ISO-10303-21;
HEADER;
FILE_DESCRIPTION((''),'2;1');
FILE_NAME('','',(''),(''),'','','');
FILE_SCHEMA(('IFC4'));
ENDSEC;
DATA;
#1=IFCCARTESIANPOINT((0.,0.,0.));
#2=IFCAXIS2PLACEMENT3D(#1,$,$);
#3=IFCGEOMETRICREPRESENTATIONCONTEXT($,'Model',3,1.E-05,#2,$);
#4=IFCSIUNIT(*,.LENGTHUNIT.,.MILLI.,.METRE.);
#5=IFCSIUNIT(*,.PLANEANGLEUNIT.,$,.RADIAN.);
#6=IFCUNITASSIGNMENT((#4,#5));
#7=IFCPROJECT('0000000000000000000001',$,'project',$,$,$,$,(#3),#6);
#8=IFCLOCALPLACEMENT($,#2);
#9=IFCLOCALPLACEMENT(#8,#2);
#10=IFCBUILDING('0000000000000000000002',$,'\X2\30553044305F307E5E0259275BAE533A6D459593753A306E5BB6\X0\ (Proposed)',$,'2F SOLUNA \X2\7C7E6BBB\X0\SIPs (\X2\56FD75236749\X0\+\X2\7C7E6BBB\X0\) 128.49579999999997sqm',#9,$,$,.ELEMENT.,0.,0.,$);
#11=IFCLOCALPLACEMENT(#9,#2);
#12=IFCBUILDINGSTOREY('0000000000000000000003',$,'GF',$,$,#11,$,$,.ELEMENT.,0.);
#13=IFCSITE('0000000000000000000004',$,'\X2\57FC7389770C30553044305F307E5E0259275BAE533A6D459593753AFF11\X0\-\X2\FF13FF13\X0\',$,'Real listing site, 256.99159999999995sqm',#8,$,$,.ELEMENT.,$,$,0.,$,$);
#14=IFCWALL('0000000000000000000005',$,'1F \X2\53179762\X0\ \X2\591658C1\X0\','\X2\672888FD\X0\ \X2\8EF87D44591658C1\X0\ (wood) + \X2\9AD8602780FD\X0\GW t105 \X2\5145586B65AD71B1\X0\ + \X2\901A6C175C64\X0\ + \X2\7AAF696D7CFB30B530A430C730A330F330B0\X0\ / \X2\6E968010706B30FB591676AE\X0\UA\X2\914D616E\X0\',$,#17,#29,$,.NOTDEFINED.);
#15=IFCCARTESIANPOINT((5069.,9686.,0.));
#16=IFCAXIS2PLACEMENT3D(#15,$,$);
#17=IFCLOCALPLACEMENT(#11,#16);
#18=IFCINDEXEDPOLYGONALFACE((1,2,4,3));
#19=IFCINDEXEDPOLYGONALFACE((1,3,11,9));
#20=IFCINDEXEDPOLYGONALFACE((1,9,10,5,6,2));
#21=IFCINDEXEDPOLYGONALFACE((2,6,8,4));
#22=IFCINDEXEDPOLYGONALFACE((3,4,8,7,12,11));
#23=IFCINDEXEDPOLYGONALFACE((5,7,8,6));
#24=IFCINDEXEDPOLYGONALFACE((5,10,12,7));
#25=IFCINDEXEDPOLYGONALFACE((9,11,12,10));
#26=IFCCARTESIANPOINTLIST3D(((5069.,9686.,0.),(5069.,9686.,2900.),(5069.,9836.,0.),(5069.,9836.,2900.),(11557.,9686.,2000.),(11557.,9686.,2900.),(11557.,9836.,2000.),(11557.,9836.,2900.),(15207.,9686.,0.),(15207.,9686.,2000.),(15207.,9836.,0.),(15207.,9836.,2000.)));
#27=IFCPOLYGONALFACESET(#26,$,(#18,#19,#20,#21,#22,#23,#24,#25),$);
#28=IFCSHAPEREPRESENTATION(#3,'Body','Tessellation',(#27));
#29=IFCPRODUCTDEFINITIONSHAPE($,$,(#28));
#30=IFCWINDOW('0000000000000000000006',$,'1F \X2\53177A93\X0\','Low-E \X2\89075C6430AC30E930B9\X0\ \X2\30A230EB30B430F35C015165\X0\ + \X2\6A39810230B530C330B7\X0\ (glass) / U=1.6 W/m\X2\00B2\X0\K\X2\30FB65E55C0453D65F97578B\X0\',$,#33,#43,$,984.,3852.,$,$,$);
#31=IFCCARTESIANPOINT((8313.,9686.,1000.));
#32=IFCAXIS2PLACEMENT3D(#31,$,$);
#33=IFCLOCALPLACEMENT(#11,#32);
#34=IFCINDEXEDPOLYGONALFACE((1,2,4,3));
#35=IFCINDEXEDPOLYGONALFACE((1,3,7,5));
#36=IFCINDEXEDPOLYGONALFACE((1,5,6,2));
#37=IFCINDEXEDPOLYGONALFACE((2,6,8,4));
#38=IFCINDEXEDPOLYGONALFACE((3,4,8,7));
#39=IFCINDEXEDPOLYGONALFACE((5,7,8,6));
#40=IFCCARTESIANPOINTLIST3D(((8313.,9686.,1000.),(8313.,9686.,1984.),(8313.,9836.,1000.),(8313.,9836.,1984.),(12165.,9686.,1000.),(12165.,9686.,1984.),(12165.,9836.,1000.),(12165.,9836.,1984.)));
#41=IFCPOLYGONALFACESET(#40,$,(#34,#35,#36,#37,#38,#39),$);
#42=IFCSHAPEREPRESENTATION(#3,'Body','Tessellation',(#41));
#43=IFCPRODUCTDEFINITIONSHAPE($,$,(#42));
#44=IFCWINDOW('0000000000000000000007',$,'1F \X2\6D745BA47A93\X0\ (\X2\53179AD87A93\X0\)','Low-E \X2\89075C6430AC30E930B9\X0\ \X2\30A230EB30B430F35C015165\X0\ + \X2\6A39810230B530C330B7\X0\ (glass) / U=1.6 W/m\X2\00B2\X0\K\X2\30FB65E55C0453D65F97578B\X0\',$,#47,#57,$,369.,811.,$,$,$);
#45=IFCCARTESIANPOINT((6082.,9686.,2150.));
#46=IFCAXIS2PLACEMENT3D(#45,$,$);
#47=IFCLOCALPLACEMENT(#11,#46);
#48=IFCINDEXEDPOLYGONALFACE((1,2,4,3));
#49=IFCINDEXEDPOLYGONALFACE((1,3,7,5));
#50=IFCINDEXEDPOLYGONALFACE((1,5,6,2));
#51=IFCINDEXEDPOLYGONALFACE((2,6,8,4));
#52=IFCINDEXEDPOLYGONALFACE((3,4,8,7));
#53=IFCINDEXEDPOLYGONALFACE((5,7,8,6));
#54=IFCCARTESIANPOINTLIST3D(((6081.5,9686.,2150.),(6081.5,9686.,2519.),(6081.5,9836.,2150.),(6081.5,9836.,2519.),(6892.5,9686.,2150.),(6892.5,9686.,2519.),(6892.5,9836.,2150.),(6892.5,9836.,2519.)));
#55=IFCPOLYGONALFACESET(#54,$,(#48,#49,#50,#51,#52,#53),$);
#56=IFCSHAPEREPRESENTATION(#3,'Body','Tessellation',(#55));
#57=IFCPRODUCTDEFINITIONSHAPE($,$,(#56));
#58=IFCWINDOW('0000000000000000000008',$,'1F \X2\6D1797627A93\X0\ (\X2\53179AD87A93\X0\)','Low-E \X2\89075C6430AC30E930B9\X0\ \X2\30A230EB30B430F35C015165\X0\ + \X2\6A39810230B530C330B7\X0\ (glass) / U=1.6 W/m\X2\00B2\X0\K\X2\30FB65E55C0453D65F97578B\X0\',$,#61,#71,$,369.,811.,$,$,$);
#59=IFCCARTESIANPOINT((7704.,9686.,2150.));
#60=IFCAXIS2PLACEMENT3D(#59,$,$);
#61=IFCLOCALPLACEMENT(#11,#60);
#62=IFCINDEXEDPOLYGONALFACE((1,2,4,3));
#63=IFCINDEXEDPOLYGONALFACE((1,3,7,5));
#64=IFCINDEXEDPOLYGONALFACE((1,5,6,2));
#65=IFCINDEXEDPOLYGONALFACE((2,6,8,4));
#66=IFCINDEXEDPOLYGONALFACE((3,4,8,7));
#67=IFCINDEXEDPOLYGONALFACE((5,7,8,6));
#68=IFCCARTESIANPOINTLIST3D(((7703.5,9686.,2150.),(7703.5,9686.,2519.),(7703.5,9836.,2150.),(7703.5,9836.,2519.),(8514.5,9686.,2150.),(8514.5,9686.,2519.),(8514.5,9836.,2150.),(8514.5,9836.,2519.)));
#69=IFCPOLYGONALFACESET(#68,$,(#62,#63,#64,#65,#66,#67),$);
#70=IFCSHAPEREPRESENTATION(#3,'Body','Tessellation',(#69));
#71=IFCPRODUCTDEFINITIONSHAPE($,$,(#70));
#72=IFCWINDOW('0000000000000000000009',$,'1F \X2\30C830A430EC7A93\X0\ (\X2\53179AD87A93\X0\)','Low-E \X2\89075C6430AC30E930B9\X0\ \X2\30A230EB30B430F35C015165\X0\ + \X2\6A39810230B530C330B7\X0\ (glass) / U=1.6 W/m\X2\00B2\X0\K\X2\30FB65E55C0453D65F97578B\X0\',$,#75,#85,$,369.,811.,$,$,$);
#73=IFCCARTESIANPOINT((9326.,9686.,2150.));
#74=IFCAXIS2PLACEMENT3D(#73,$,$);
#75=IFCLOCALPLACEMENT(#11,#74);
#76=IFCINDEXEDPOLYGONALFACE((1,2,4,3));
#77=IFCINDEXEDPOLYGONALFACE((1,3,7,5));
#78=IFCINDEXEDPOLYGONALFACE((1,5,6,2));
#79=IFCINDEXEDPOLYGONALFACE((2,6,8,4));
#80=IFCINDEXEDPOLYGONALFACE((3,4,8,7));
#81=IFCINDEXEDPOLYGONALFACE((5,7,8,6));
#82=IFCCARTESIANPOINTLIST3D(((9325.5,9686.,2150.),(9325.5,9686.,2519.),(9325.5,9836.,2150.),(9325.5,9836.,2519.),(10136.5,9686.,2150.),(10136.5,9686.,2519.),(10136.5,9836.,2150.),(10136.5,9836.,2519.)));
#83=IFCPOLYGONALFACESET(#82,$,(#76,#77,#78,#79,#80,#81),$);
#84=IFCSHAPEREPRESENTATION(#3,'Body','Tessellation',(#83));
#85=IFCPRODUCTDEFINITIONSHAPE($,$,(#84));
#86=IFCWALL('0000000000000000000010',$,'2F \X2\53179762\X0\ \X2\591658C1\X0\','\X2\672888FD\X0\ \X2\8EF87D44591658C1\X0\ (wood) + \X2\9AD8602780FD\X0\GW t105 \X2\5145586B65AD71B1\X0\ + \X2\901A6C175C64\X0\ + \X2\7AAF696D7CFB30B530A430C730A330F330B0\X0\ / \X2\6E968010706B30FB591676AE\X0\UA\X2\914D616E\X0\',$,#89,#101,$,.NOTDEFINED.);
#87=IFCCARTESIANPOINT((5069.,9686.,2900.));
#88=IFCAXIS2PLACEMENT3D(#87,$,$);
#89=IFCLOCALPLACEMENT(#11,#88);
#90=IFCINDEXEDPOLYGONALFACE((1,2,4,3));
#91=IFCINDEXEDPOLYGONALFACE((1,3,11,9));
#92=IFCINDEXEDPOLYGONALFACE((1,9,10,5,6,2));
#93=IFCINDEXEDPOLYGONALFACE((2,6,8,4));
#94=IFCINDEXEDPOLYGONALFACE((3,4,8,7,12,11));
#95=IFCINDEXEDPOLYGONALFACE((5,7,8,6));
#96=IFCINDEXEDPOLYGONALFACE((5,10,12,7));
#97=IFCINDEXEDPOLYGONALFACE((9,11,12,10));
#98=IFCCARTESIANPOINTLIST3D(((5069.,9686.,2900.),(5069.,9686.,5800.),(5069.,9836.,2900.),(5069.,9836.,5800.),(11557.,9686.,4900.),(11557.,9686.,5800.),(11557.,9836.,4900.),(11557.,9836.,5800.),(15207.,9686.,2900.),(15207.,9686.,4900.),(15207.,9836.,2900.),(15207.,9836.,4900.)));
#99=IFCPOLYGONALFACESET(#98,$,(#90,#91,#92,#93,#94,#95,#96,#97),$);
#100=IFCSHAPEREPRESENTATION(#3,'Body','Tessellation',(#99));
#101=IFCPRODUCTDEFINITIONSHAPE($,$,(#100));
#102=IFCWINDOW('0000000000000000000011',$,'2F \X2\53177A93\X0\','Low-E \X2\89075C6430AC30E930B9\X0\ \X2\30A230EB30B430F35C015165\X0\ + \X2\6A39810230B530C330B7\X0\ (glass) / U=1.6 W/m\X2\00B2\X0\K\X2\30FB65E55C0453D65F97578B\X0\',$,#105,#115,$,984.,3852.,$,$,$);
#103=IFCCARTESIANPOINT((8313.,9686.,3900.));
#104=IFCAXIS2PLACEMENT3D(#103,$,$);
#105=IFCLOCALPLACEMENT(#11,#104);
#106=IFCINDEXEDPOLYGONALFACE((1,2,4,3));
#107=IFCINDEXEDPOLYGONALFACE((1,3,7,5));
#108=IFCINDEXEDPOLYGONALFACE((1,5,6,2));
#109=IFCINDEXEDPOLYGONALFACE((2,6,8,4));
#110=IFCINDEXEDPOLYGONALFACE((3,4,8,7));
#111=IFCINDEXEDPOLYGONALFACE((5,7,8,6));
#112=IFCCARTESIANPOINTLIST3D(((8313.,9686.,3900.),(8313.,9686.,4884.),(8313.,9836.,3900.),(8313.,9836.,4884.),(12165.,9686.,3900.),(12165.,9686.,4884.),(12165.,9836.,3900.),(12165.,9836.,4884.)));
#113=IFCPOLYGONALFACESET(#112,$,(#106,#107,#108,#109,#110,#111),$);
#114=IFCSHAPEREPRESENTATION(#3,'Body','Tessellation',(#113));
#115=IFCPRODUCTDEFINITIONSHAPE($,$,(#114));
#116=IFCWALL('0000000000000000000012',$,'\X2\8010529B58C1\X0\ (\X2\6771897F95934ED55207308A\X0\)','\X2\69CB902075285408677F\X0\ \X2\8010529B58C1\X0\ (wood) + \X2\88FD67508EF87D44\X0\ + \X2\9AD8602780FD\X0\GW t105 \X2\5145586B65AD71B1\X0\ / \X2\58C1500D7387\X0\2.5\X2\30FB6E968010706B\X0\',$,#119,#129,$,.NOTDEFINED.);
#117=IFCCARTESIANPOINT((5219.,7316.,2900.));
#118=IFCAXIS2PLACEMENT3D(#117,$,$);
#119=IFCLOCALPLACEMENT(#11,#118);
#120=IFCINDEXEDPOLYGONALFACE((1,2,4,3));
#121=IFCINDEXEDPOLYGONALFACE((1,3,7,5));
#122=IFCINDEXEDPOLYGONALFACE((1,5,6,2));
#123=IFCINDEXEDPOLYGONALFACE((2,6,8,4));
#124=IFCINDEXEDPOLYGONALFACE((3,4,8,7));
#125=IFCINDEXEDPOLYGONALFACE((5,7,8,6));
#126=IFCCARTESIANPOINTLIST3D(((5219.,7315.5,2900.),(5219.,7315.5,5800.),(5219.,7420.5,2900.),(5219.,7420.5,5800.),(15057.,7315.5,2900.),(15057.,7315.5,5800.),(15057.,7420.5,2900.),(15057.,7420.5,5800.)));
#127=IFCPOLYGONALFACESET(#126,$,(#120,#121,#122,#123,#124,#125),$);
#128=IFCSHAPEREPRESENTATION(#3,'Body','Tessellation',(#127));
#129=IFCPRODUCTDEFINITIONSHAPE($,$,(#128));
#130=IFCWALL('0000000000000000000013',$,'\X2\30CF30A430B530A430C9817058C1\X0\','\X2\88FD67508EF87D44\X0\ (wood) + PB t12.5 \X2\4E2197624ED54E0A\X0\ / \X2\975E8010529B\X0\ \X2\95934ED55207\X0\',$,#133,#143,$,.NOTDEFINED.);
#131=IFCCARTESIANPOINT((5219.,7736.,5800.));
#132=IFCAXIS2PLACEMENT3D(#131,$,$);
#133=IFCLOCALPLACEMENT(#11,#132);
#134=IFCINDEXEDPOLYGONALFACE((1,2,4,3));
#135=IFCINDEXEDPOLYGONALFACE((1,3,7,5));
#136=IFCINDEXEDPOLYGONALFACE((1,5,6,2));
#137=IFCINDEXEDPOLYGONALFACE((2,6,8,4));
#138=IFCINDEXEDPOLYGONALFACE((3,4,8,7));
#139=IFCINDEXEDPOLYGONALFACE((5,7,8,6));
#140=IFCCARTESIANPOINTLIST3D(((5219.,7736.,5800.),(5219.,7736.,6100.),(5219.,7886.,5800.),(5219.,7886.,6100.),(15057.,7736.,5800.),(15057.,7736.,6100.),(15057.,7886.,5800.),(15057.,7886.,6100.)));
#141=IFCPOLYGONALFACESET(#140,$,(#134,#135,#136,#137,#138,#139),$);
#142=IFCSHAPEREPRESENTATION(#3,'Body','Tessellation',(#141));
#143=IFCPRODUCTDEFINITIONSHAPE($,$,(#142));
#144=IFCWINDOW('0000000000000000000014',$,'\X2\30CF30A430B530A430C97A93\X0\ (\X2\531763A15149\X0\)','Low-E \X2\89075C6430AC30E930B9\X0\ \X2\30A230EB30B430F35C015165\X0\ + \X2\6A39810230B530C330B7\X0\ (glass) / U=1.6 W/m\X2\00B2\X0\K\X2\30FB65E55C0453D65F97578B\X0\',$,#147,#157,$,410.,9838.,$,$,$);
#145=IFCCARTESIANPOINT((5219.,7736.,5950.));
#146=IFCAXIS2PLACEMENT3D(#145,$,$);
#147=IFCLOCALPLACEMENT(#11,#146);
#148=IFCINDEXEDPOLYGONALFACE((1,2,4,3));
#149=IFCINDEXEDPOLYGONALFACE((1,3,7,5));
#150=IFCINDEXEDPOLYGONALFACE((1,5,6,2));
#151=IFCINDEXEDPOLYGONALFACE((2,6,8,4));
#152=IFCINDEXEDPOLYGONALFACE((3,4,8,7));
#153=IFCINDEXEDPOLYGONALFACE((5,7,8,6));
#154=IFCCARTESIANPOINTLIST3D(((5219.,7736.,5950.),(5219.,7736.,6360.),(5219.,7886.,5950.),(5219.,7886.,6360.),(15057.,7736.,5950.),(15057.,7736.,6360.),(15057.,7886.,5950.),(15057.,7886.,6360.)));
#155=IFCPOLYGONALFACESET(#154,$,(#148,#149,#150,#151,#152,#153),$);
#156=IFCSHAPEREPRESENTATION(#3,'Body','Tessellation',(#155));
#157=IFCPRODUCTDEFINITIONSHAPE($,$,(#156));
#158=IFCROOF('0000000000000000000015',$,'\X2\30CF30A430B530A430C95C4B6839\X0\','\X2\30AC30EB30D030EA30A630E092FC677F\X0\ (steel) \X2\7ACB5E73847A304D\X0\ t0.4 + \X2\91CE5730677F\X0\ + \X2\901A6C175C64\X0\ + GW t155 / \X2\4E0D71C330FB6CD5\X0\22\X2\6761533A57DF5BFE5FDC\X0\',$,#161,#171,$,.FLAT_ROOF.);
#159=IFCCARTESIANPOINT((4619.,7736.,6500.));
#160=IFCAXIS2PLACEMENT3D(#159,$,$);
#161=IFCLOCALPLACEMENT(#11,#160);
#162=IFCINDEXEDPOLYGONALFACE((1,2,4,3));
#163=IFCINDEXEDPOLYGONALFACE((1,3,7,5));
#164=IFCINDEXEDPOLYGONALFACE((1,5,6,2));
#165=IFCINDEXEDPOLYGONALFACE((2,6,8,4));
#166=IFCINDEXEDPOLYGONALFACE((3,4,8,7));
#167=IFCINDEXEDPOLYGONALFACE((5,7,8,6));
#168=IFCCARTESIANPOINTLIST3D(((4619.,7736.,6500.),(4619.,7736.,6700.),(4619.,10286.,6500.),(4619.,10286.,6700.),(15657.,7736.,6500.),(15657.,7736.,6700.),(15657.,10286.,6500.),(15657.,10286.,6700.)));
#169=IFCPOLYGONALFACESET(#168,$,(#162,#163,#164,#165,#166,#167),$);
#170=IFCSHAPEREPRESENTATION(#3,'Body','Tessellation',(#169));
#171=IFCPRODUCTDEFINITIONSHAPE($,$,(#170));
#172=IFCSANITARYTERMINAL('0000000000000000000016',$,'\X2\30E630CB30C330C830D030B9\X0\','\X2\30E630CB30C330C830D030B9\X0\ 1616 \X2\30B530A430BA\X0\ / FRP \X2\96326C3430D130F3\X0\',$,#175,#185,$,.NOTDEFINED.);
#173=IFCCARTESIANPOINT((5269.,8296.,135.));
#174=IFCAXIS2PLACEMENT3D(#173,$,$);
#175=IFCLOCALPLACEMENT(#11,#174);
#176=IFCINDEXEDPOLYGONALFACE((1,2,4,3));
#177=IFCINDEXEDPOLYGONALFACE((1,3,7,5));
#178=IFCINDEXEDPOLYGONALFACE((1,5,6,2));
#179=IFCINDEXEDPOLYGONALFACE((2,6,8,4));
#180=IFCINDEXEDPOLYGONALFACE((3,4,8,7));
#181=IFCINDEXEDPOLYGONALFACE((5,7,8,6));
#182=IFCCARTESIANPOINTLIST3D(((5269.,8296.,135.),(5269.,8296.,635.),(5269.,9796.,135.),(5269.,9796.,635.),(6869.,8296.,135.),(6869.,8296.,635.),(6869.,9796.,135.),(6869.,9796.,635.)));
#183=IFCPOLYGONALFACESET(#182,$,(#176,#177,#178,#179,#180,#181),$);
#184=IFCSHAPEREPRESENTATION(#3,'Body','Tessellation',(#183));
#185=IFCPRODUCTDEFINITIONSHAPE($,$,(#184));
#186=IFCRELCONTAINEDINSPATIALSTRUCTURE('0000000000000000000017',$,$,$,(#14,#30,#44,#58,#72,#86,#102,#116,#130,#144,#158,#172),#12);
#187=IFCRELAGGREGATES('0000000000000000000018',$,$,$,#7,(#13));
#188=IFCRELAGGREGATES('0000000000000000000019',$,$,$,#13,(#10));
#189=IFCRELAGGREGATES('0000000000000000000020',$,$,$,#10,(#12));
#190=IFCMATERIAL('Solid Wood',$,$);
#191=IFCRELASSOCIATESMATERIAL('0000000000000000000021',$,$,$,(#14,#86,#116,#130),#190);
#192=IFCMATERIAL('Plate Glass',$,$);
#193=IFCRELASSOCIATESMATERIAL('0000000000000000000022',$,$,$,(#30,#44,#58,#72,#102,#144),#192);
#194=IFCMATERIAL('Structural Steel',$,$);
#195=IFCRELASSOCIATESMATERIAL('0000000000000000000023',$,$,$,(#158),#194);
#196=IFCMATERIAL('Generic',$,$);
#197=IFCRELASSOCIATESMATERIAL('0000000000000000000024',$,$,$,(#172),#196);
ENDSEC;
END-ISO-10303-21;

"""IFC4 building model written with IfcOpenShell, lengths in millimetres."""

from ifc_helpers import new_model, si_unit, frame, frame_2d, origin, place, context, project, spatial, rectangle, extrude, material, element, fill, save


model = new_model("IFC4")

# Units and contexts
model_context = context("Model", 3, precision=1e-05, world=origin())
ifc_project = project(units=[si_unit("LENGTHUNIT", "METRE", prefix="MILLI"), si_unit("PLANEANGLEUNIT", "RADIAN")], contexts=[model_context])

# Site, building, storey
site_placement = place(None, origin())
site = spatial("IfcSite", under=ifc_project, at=site_placement, Name="埼玉県さいたま市大宮区浅間町１-３３", ObjectType="Real listing site, 256.99159999999995sqm", CompositionType="ELEMENT", RefElevation=0.0)
building_placement = place(site_placement, origin())
building = spatial("IfcBuilding", under=site, at=building_placement, Name="さいたま市大宮区浅間町の家 (Proposed)", ObjectType="2F SOLUNA 籾殻SIPs (国産杉+籾殻) 128.49579999999997sqm", CompositionType="ELEMENT", ElevationOfRefHeight=0.0, ElevationOfTerrain=0.0)
storey_placement = place(building_placement, origin())
storey = spatial("IfcBuildingStorey", under=building, at=storey_placement, Name="GF", CompositionType="ELEMENT", Elevation=0.0)

# Wall, openings, windows
ifc_material_1 = material(Name="Solid Wood")
wall_1_placement = place(storey_placement, frame((5069.0, 9686.0, 0.0)))
wall_1 = element("IfcWall", 1, at=wall_1_placement, inside=storey, material=ifc_material_1, Name="1F 北面 外壁", Description="木製 軸組外壁 (wood) + 高性能GW t105 充填断熱 + 通気層 + 窯業系サイディング / 準耐火・外皮UA配慮", PredefinedType="NOTDEFINED", context=model_context, shape_type="SweptSolid", body=[
    extrude(rectangle(XDim=10138.0, YDim=150.0, at=frame_2d((5069.0, 75.0))), frame((5069.0, 9686.0, 0.0)), (0.0, 0.0, 1.0), 2900.0),
])
opening_1_placement = place(storey_placement, frame((8313.0, 9686.0, 1000.0)))
opening_1 = element("IfcOpeningElement", 2, at=opening_1_placement, cuts=wall_1, PredefinedType="NOTDEFINED", context=model_context, shape_type="SweptSolid", body=[
    extrude(rectangle(XDim=3852.0, YDim=150.0, at=frame_2d((1926.0, 75.0))), frame((8313.0, 9686.0, 1000.0)), (0.0, 0.0, 1.0), 984.0),
])
opening_2_placement = place(storey_placement, frame((6082.0, 9686.0, 2150.0)))
opening_2 = element("IfcOpeningElement", 3, at=opening_2_placement, cuts=wall_1, PredefinedType="NOTDEFINED", context=model_context, shape_type="SweptSolid", body=[
    extrude(rectangle(XDim=811.0, YDim=150.0, at=frame_2d((405.0, 75.0))), frame((6082.0, 9686.0, 2150.0)), (0.0, 0.0, 1.0), 369.0),
])
opening_3_placement = place(storey_placement, frame((7704.0, 9686.0, 2150.0)))
opening_3 = element("IfcOpeningElement", 4, at=opening_3_placement, cuts=wall_1, PredefinedType="NOTDEFINED", context=model_context, shape_type="SweptSolid", body=[
    extrude(rectangle(XDim=811.0, YDim=150.0, at=frame_2d((405.0, 75.0))), frame((7704.0, 9686.0, 2150.0)), (0.0, 0.0, 1.0), 369.0),
])
opening_4_placement = place(storey_placement, frame((9326.0, 9686.0, 2150.0)))
opening_4 = element("IfcOpeningElement", 5, at=opening_4_placement, cuts=wall_1, PredefinedType="NOTDEFINED", context=model_context, shape_type="SweptSolid", body=[
    extrude(rectangle(XDim=811.0, YDim=150.0, at=frame_2d((405.0, 75.0))), frame((9326.0, 9686.0, 2150.0)), (0.0, 0.0, 1.0), 369.0),
])
ifc_material_2 = material(Name="Plate Glass")
window_1_placement = place(storey_placement, frame((8313.0, 9686.0, 1000.0)))
window_1 = element("IfcWindow", 6, at=window_1_placement, inside=storey, material=ifc_material_2, Name="1F 北窓", Description="Low-E 複層ガラス アルゴン封入 + 樹脂サッシ (glass) / U=1.6 W/m²K・日射取得型", OverallHeight=984.0, OverallWidth=3852.0, context=model_context, shape_type="SweptSolid", body=[
    extrude(rectangle(XDim=3852.0, YDim=150.0, at=frame_2d((1926.0, 75.0))), frame((8313.0, 9686.0, 1000.0)), (0.0, 0.0, 1.0), 984.0),
])
fill(opening_1, window_1)
window_2_placement = place(storey_placement, frame((6082.0, 9686.0, 2150.0)))
window_2 = element("IfcWindow", 7, at=window_2_placement, inside=storey, material=ifc_material_2, Name="1F 浴室窓 (北高窓)", Description="Low-E 複層ガラス アルゴン封入 + 樹脂サッシ (glass) / U=1.6 W/m²K・日射取得型", OverallHeight=369.0, OverallWidth=811.0, context=model_context, shape_type="SweptSolid", body=[
    extrude(rectangle(XDim=811.0, YDim=150.0, at=frame_2d((405.0, 75.0))), frame((6082.0, 9686.0, 2150.0)), (0.0, 0.0, 1.0), 369.0),
])
fill(opening_2, window_2)
window_3_placement = place(storey_placement, frame((7704.0, 9686.0, 2150.0)))
window_3 = element("IfcWindow", 8, at=window_3_placement, inside=storey, material=ifc_material_2, Name="1F 洗面窓 (北高窓)", Description="Low-E 複層ガラス アルゴン封入 + 樹脂サッシ (glass) / U=1.6 W/m²K・日射取得型", OverallHeight=369.0, OverallWidth=811.0, context=model_context, shape_type="SweptSolid", body=[
    extrude(rectangle(XDim=811.0, YDim=150.0, at=frame_2d((405.0, 75.0))), frame((7704.0, 9686.0, 2150.0)), (0.0, 0.0, 1.0), 369.0),
])
fill(opening_3, window_3)
window_4_placement = place(storey_placement, frame((9326.0, 9686.0, 2150.0)))
window_4 = element("IfcWindow", 9, at=window_4_placement, inside=storey, material=ifc_material_2, Name="1F トイレ窓 (北高窓)", Description="Low-E 複層ガラス アルゴン封入 + 樹脂サッシ (glass) / U=1.6 W/m²K・日射取得型", OverallHeight=369.0, OverallWidth=811.0, context=model_context, shape_type="SweptSolid", body=[
    extrude(rectangle(XDim=811.0, YDim=150.0, at=frame_2d((405.0, 75.0))), frame((9326.0, 9686.0, 2150.0)), (0.0, 0.0, 1.0), 369.0),
])
fill(opening_4, window_4)

# Wall, opening, window
wall_2_placement = place(storey_placement, frame((5069.0, 9686.0, 2900.0)))
wall_2 = element("IfcWall", 10, at=wall_2_placement, inside=storey, material=ifc_material_1, Name="2F 北面 外壁", Description="木製 軸組外壁 (wood) + 高性能GW t105 充填断熱 + 通気層 + 窯業系サイディング / 準耐火・外皮UA配慮", PredefinedType="NOTDEFINED", context=model_context, shape_type="SweptSolid", body=[
    extrude(rectangle(XDim=10138.0, YDim=150.0, at=frame_2d((5069.0, 75.0))), frame((5069.0, 9686.0, 2900.0)), (0.0, 0.0, 1.0), 2900.0),
])
opening_5_placement = place(storey_placement, frame((8313.0, 9686.0, 3900.0)))
opening_5 = element("IfcOpeningElement", 11, at=opening_5_placement, cuts=wall_2, PredefinedType="NOTDEFINED", context=model_context, shape_type="SweptSolid", body=[
    extrude(rectangle(XDim=3852.0, YDim=150.0, at=frame_2d((1926.0, 75.0))), frame((8313.0, 9686.0, 3900.0)), (0.0, 0.0, 1.0), 984.0),
])
window_5_placement = place(storey_placement, frame((8313.0, 9686.0, 3900.0)))
window_5 = element("IfcWindow", 12, at=window_5_placement, inside=storey, material=ifc_material_2, Name="2F 北窓", Description="Low-E 複層ガラス アルゴン封入 + 樹脂サッシ (glass) / U=1.6 W/m²K・日射取得型", OverallHeight=984.0, OverallWidth=3852.0, context=model_context, shape_type="SweptSolid", body=[
    extrude(rectangle(XDim=3852.0, YDim=150.0, at=frame_2d((1926.0, 75.0))), frame((8313.0, 9686.0, 3900.0)), (0.0, 0.0, 1.0), 984.0),
])
fill(opening_5, window_5)

# Wall
wall_3_placement = place(storey_placement, frame((5219.0, 7316.0, 2900.0)))
element("IfcWall", 13, at=wall_3_placement, inside=storey, material=ifc_material_1, Name="耐力壁 (東西間仕切り)", Description="構造用合板 耐力壁 (wood) + 製材軸組 + 高性能GW t105 充填断熱 / 壁倍率2.5・準耐火", PredefinedType="NOTDEFINED", context=model_context, shape_type="SweptSolid", body=[
    extrude(rectangle(XDim=9838.0, YDim=105.0, at=frame_2d((4919.0, 52.0))), frame((5219.0, 7316.0, 2900.0)), (0.0, 0.0, 1.0), 2900.0),
])

# Wall, opening, window
wall_4_placement = place(storey_placement, frame((5219.0, 7736.0, 5800.0)))
wall_4 = element("IfcWall", 14, at=wall_4_placement, inside=storey, material=ifc_material_1, Name="ハイサイド腰壁", Description="製材軸組 (wood) + PB t12.5 両面仕上 / 非耐力 間仕切", PredefinedType="NOTDEFINED", context=model_context, shape_type="SweptSolid", body=[
    extrude(rectangle(XDim=9838.0, YDim=150.0, at=frame_2d((4919.0, 75.0))), frame((5219.0, 7736.0, 5800.0)), (0.0, 0.0, 1.0), 700.0),
])
opening_6_placement = place(storey_placement, frame((5219.0, 7736.0, 5950.0)))
opening_6 = element("IfcOpeningElement", 15, at=opening_6_placement, cuts=wall_4, PredefinedType="NOTDEFINED", context=model_context, shape_type="SweptSolid", body=[
    extrude(rectangle(XDim=9838.0, YDim=150.0, at=frame_2d((4919.0, 75.0))), frame((5219.0, 7736.0, 5950.0)), (0.0, 0.0, 1.0), 410.0),
])
window_6_placement = place(storey_placement, frame((5219.0, 7736.0, 5950.0)))
window_6 = element("IfcWindow", 16, at=window_6_placement, inside=storey, material=ifc_material_2, Name="ハイサイド窓 (北採光)", Description="Low-E 複層ガラス アルゴン封入 + 樹脂サッシ (glass) / U=1.6 W/m²K・日射取得型", OverallHeight=410.0, OverallWidth=9838.0, context=model_context, shape_type="SweptSolid", body=[
    extrude(rectangle(XDim=9838.0, YDim=150.0, at=frame_2d((4919.0, 75.0))), frame((5219.0, 7736.0, 5950.0)), (0.0, 0.0, 1.0), 410.0),
])
fill(opening_6, window_6)

# Roof
ifc_material_3 = material(Name="Structural Steel")
roof_placement = place(storey_placement, frame((4619.0, 7736.0, 6500.0)))
element("IfcRoof", 17, at=roof_placement, inside=storey, material=ifc_material_3, Name="ハイサイド屋根", Description="ガルバリウム鋼板 (steel) 立平葺き t0.4 + 野地板 + 通気層 + GW t155 / 不燃・法22条区域対応", PredefinedType="FLAT_ROOF", context=model_context, shape_type="SweptSolid", body=[
    extrude(rectangle(XDim=11038.0, YDim=2550.0, at=frame_2d((5519.0, 1275.0))), frame((4619.0, 7736.0, 6500.0)), (0.0, 0.0, 1.0), 200.0),
])

# Sanitary terminal
ifc_material_4 = material(Name="Generic")
sanitary_terminal_placement = place(storey_placement, frame((5269.0, 8296.0, 135.0)))
element("IfcSanitaryTerminal", 18, at=sanitary_terminal_placement, inside=storey, material=ifc_material_4, Name="ユニットバス", Description="ユニットバス 1616 サイズ / FRP 防水パン", PredefinedType="NOTDEFINED", context=model_context, shape_type="SweptSolid", body=[
    extrude(rectangle(XDim=1600.0, YDim=1500.0, at=frame_2d((800.0, 750.0))), frame((5269.0, 8296.0, 135.0)), (0.0, 0.0, 1.0), 500.0),
])

save(model, "model.ifc")
